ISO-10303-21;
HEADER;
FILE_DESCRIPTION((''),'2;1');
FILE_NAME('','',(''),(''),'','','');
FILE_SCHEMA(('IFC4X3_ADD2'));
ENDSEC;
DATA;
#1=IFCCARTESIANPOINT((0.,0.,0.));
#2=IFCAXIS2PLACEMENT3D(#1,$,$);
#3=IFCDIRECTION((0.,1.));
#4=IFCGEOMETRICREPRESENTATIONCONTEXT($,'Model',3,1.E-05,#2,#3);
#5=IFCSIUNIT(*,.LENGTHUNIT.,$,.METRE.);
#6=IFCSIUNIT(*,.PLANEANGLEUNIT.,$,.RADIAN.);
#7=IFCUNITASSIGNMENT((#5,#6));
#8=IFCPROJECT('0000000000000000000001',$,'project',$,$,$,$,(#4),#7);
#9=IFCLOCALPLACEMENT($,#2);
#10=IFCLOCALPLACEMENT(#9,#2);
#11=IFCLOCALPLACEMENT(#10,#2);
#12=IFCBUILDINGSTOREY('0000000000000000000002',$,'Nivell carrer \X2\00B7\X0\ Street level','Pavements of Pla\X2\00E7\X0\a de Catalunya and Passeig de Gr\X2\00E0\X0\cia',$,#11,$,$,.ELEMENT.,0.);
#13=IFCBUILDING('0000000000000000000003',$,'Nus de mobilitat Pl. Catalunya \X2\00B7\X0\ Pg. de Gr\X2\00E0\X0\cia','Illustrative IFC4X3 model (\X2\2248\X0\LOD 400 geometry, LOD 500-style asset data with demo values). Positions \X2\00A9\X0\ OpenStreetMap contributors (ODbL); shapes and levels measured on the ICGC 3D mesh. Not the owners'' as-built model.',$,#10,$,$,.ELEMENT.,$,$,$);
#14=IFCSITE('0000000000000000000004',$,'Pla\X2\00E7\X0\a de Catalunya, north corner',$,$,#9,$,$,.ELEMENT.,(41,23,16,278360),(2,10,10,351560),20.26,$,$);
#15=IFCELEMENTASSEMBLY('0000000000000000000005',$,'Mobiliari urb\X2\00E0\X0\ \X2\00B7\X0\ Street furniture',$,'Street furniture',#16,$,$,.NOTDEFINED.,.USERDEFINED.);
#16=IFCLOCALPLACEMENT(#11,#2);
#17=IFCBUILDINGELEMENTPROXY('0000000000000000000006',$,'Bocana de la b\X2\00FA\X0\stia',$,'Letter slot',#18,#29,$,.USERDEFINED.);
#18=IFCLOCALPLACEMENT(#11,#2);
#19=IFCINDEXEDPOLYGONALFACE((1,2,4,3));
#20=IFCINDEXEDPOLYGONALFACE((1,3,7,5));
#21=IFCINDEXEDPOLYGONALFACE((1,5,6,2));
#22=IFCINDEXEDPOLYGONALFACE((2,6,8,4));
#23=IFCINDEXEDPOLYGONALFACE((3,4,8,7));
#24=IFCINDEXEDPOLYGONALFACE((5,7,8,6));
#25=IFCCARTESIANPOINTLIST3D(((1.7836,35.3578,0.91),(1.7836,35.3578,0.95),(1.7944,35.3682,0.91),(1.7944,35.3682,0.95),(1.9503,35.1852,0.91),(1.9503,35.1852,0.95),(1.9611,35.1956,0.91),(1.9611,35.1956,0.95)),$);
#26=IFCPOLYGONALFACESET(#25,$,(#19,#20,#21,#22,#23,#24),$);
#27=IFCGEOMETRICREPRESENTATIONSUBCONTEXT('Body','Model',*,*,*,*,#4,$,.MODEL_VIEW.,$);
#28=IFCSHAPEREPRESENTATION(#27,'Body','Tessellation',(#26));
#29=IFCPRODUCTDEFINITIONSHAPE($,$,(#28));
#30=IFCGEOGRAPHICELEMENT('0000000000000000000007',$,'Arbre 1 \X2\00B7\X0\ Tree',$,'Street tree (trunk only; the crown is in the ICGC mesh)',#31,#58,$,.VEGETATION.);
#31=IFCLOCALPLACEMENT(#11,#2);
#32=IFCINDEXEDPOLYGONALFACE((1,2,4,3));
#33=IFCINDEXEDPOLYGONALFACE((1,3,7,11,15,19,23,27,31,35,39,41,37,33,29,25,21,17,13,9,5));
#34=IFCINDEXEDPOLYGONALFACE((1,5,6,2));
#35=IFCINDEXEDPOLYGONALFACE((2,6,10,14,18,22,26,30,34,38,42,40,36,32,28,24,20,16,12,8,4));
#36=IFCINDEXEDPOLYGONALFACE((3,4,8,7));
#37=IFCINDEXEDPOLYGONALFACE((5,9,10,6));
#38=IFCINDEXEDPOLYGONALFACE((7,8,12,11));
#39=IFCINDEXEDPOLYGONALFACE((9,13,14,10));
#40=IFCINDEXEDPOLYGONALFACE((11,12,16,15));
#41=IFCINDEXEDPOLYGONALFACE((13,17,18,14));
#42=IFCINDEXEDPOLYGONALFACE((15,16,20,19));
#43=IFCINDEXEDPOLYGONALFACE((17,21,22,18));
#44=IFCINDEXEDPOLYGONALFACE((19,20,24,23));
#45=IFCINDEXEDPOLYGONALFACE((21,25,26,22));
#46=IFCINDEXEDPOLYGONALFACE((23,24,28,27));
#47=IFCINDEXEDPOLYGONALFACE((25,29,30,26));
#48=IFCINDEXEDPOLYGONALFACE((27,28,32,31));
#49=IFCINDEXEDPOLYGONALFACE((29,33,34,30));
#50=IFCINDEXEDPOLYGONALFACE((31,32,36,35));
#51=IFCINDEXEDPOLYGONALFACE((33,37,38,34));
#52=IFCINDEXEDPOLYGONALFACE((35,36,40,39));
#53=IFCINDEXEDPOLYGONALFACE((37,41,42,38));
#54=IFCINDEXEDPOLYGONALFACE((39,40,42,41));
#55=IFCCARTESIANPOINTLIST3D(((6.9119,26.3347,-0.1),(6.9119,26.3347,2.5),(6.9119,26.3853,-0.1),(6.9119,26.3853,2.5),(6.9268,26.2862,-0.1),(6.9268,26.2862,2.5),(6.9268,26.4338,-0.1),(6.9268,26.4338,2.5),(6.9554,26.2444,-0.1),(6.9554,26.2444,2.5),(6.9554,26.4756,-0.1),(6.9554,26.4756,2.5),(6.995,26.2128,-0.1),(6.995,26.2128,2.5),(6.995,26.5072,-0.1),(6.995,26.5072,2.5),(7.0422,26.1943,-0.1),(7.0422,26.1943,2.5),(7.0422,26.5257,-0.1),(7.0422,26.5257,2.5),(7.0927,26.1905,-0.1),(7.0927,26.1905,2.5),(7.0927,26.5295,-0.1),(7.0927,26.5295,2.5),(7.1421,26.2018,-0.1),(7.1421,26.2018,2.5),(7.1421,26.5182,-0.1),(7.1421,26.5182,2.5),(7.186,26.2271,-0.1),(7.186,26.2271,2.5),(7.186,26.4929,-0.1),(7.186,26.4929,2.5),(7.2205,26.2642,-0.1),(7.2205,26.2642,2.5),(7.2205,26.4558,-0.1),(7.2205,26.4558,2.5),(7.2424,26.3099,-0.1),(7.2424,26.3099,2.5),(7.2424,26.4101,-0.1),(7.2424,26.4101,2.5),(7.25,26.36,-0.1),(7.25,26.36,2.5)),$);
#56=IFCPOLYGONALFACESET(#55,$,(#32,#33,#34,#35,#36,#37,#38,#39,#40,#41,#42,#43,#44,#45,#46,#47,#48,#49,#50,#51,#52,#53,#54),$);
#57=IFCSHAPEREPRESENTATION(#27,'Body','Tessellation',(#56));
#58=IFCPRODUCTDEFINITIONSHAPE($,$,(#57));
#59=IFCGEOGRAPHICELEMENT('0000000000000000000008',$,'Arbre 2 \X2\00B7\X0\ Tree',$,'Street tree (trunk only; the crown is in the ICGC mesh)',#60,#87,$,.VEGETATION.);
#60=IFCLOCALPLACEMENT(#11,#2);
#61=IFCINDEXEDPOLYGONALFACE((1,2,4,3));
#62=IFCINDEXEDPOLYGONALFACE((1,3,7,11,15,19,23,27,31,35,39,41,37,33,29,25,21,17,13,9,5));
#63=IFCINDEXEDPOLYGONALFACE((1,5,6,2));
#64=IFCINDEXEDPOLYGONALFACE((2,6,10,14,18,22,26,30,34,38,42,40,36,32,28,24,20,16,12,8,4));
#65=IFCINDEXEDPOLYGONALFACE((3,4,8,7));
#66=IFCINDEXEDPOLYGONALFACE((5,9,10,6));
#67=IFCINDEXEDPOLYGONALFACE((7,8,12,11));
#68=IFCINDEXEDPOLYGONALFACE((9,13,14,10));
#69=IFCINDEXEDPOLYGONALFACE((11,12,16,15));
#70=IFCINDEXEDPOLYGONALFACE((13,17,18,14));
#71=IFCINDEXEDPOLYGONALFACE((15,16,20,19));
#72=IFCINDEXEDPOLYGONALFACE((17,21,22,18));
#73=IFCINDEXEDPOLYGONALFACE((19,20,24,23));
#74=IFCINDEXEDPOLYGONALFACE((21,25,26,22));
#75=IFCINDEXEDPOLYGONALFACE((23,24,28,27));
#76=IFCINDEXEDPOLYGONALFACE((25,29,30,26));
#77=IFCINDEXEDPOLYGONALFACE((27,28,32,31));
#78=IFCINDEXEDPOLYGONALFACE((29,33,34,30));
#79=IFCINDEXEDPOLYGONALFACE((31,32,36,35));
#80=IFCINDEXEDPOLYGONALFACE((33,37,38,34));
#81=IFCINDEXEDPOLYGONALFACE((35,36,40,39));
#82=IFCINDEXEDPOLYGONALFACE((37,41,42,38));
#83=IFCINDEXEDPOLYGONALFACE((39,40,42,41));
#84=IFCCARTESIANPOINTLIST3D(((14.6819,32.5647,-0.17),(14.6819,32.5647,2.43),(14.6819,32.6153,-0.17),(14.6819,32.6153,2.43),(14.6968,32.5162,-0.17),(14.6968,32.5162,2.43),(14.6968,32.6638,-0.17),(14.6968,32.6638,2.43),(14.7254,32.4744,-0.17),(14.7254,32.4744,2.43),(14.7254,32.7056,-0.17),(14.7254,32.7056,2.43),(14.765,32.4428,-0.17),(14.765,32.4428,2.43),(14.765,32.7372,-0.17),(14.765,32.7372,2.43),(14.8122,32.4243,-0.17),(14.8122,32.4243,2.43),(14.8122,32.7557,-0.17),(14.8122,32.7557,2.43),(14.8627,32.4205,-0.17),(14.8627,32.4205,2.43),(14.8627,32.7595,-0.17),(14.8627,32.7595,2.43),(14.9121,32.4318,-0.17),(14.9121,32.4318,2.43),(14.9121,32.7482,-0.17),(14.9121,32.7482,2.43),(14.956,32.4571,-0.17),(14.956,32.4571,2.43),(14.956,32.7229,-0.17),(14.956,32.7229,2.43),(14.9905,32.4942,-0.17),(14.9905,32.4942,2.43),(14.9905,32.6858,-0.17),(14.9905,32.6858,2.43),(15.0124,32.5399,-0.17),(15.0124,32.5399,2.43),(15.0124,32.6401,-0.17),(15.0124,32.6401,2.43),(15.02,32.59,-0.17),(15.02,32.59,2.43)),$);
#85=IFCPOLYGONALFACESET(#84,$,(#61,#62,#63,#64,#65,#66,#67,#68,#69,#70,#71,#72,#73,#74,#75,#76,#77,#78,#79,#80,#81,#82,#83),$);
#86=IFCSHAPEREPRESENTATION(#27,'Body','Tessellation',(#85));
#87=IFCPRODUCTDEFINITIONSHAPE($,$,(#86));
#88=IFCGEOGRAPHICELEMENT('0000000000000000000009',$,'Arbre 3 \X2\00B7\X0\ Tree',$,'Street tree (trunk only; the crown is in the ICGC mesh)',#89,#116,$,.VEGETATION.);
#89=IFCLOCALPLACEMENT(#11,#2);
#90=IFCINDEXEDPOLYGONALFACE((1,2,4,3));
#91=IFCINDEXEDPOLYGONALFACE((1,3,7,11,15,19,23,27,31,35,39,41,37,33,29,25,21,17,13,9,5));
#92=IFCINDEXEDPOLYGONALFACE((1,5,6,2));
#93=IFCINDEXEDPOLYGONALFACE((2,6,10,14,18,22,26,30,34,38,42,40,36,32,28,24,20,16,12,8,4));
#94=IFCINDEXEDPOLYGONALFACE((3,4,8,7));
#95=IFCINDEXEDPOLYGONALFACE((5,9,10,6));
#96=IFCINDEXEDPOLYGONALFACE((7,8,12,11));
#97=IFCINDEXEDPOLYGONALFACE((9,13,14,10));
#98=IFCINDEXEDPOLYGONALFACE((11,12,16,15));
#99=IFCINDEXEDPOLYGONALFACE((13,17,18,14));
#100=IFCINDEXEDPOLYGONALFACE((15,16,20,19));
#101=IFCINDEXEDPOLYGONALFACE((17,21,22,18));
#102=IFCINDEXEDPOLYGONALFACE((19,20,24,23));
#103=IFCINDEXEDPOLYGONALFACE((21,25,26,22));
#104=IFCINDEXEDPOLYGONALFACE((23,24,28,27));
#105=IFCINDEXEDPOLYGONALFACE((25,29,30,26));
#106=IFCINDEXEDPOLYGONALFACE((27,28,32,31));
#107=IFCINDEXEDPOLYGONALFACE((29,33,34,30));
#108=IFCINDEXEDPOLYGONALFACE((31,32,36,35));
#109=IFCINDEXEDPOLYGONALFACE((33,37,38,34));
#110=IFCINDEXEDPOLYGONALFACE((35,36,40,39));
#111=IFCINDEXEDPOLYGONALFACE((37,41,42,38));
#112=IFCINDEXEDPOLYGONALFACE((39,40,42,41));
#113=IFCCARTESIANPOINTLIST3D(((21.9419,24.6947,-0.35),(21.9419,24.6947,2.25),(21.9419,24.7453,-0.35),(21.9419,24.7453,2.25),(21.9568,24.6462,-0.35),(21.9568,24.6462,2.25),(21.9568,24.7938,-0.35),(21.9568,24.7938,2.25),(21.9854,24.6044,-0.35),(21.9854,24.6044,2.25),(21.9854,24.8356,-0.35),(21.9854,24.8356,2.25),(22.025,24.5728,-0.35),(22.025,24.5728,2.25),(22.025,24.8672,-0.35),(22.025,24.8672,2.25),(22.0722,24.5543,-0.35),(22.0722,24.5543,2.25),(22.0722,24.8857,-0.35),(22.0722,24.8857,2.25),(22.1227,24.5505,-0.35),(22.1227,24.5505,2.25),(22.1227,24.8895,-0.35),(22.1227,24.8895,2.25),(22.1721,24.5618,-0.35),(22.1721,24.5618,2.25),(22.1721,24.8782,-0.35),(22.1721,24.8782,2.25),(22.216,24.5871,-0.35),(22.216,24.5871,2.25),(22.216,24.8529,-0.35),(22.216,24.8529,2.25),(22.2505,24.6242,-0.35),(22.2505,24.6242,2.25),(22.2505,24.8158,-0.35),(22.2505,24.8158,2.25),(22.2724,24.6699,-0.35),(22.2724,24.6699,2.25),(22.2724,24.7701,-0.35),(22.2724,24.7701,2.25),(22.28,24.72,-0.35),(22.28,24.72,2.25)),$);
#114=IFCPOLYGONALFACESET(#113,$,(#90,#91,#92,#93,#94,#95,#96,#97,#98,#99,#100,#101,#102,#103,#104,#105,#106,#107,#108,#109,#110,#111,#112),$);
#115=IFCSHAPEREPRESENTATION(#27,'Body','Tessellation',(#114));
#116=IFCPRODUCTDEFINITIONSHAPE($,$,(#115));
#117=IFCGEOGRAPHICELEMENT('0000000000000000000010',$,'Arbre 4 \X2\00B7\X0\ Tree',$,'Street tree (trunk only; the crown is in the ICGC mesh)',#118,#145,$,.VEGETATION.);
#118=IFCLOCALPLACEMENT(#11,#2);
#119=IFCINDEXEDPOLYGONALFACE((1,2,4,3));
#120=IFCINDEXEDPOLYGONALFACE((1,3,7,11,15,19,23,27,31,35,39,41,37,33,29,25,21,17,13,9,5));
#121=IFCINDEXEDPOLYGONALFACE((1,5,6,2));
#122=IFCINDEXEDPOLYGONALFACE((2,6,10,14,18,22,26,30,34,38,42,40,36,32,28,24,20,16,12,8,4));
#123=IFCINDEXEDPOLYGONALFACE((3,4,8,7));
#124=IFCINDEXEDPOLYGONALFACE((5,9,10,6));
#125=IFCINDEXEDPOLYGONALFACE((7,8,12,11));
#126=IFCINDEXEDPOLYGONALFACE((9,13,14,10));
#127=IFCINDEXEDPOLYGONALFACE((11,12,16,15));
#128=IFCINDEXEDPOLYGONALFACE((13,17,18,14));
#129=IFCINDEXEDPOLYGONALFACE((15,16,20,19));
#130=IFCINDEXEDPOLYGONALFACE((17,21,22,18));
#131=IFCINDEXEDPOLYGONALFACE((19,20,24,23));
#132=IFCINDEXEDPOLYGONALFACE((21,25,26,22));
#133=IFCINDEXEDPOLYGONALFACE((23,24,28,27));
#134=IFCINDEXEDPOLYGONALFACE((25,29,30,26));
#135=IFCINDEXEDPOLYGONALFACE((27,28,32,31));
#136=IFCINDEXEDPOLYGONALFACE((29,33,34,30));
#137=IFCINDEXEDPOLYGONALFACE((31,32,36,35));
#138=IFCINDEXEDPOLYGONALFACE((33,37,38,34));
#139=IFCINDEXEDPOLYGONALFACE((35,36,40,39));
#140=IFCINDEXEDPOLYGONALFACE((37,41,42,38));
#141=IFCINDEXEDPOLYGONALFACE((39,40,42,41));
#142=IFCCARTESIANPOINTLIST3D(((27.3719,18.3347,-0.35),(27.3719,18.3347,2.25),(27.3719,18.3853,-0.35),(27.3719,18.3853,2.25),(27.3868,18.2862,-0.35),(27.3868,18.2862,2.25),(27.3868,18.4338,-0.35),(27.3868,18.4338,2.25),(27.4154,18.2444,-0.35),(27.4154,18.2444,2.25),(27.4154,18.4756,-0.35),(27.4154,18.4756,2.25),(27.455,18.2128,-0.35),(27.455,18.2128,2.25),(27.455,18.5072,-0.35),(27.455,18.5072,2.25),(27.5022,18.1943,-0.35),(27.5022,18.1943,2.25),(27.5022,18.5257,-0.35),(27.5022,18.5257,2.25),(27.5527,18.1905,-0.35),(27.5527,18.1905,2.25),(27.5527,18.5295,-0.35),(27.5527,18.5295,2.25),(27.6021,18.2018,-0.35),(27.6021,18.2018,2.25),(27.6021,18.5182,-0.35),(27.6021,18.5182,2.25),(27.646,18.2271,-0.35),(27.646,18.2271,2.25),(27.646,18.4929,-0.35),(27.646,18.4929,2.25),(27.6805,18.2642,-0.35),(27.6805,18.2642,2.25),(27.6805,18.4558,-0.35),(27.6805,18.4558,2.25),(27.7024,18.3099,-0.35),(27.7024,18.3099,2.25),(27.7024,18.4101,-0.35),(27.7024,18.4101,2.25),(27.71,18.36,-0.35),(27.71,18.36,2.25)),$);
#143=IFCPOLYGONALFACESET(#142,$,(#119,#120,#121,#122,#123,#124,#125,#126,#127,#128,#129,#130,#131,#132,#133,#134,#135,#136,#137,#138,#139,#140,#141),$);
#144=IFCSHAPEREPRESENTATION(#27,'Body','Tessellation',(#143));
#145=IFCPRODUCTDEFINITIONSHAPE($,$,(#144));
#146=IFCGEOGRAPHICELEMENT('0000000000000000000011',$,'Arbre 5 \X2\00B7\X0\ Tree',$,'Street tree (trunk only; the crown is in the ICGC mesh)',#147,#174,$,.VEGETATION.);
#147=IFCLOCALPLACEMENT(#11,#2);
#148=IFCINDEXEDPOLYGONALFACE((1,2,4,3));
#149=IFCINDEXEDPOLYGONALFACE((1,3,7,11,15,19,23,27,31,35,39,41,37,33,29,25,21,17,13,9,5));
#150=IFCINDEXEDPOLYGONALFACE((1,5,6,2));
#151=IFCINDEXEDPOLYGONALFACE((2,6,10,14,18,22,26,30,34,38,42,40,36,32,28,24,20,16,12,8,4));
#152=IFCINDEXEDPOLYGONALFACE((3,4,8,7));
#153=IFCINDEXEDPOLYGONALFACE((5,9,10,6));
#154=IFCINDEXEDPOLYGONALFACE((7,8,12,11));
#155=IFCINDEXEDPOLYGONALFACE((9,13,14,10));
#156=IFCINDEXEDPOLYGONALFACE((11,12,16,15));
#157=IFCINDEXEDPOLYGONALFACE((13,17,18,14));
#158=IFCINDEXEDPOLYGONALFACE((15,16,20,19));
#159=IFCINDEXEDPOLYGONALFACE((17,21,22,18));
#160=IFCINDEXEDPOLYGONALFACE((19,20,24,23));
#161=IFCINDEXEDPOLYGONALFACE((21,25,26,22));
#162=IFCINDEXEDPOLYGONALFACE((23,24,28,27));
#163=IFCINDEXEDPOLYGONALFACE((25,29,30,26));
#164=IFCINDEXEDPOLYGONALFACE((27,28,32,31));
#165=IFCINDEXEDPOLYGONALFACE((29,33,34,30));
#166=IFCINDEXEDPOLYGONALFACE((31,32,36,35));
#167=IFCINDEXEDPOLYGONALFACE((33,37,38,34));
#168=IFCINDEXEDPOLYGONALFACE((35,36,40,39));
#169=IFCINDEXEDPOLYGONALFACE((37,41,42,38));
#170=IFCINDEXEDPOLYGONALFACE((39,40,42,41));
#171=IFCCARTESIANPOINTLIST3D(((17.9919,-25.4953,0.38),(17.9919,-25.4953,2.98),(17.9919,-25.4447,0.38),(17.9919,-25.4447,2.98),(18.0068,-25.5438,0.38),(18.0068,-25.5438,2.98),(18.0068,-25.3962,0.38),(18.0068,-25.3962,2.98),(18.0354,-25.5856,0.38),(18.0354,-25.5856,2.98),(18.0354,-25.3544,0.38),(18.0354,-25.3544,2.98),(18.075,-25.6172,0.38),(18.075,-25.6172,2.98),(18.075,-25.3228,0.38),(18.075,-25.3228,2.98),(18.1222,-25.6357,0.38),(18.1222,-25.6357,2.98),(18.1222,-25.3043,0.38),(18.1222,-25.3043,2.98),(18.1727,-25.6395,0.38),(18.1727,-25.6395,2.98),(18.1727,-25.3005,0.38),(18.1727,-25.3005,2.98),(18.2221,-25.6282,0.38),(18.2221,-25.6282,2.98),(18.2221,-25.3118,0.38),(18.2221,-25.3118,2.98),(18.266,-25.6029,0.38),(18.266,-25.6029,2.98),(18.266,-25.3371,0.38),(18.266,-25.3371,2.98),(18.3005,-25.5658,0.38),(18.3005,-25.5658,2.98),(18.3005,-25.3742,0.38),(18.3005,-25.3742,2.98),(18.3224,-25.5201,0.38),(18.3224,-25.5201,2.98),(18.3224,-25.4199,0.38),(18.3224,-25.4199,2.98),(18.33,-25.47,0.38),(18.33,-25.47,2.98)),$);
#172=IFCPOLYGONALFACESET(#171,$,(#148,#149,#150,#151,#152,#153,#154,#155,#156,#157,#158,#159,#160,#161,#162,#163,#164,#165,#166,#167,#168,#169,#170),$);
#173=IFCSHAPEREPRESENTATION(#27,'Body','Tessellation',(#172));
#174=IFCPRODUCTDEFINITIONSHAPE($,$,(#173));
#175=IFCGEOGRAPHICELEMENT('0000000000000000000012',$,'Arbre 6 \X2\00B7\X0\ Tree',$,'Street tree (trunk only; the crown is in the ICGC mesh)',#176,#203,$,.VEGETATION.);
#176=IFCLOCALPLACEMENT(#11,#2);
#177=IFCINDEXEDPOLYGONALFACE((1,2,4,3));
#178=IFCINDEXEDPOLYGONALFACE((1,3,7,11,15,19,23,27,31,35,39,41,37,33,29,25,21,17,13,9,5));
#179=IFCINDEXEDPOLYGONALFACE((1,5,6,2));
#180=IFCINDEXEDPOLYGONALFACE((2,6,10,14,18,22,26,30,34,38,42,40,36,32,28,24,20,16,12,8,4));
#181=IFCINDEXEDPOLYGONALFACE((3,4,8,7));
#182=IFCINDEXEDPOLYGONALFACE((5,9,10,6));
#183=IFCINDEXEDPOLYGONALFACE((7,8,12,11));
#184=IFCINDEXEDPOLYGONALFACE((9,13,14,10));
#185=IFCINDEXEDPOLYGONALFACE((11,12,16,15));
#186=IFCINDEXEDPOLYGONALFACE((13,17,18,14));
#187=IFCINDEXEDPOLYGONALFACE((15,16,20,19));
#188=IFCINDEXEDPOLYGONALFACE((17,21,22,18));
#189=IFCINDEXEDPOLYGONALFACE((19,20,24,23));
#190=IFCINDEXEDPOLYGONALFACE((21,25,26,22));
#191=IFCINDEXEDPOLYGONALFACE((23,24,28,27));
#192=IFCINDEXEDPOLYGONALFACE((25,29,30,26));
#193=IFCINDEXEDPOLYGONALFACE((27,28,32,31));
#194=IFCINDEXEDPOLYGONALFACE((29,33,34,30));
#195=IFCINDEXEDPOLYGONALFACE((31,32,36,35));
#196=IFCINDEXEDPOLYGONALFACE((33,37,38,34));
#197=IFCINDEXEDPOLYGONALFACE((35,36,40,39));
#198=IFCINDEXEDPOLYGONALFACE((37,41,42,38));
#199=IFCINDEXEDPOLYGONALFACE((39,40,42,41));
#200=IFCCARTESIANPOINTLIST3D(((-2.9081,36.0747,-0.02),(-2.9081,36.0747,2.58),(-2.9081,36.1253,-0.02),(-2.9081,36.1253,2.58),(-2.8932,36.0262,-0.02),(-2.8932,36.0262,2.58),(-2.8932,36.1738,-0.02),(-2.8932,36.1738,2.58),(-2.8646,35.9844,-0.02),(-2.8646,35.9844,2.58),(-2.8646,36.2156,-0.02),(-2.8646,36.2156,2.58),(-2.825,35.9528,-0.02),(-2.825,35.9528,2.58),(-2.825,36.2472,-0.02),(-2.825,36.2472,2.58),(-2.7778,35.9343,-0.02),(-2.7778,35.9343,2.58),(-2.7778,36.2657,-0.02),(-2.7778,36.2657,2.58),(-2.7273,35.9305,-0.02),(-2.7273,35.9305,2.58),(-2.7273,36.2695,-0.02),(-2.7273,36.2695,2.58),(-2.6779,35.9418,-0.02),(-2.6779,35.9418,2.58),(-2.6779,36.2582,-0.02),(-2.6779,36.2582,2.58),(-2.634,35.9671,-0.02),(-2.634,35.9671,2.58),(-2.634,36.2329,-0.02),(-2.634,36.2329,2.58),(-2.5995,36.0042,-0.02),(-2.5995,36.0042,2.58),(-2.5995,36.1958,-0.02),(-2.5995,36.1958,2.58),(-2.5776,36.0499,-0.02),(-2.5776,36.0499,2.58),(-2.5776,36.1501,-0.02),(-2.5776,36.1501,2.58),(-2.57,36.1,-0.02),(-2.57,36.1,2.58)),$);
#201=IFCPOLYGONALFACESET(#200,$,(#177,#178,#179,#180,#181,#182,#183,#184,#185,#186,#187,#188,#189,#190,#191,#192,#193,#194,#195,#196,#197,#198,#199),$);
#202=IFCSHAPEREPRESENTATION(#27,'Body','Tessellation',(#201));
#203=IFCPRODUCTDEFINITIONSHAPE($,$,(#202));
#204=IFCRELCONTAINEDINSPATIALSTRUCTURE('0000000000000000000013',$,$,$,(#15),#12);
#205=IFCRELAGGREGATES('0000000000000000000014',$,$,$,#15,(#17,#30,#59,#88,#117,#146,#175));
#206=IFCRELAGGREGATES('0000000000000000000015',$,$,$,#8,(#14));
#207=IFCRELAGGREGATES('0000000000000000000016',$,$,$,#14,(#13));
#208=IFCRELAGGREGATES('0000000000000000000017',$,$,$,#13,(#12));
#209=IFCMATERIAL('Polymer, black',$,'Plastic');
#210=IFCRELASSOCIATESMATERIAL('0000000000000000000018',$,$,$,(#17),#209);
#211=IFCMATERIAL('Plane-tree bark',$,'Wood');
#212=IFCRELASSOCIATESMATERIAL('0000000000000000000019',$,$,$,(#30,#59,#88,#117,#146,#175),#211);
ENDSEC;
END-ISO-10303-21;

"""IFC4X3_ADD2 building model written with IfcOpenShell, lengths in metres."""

from ifc_helpers import new_model, si_unit, direction, frame, frame_2d, origin, origin_2d_with_axis, place, context, subcontext, project, spatial, rectangle, circle, extrude, material, element, aggregate, save


model = new_model("IFC4X3_ADD2")

# Units and contexts
model_context = context("Model", 3, precision=1e-05, world=origin(), true_north=direction((0.0, 1.0)))
body_context = subcontext(model_context, "Body", "Model", "MODEL_VIEW")
ifc_project = project(units=[si_unit("LENGTHUNIT", "METRE"), si_unit("PLANEANGLEUNIT", "RADIAN")], contexts=[model_context])

# Site, building, storey
site_placement = place(None, origin())
site = spatial("IfcSite", under=ifc_project, at=site_placement, Name="Plaça de Catalunya, north corner", CompositionType="ELEMENT", RefLatitude=(41, 23, 16, 278360), RefLongitude=(2, 10, 10, 351560), RefElevation=20.26)
building_placement = place(site_placement, origin())
building = spatial("IfcBuilding", under=site, at=building_placement, Name="Nus de mobilitat Pl. Catalunya · Pg. de Gràcia", Description="Illustrative IFC4X3 model (≈LOD 400 geometry, LOD 500-style asset data with demo values). Positions © OpenStreetMap contributors (ODbL); shapes and levels measured on the ICGC 3D mesh. Not the owners' as-built model.", CompositionType="ELEMENT")
storey_placement = place(building_placement, origin())
storey = spatial("IfcBuildingStorey", under=building, at=storey_placement, Name="Nivell carrer · Street level", Description="Pavements of Plaça de Catalunya and Passeig de Gràcia", CompositionType="ELEMENT", Elevation=0.0)

# Element assembly
assembly_1_placement = place(building_placement, origin())
assembly_1 = element("IfcElementAssembly", 1, at=assembly_1_placement, inside=storey, Name="Mobiliari urbà · Street furniture", ObjectType="Street furniture", AssemblyPlace="NOTDEFINED", PredefinedType="USERDEFINED")

# Building element proxy
ifc_material_1 = material(Name="Polymer, black", Category="Plastic")
proxy_1_placement = place(building_placement, origin())
proxy_1 = element("IfcBuildingElementProxy", 2, at=proxy_1_placement, material=ifc_material_1, Name="Bocana de la bústia", ObjectType="Letter slot", PredefinedType="USERDEFINED", context=body_context, shape_type="SweptSolid", body=[
    extrude(rectangle(XDim=0.24, YDim=0.015, at=frame_2d((0.0, 0.0), x_axis=(0.694658, -0.71934))), frame((1.8723, 35.2767, 0.91)), (0.0, 0.0, 1.0), 0.04),
])

# Geographic elements
ifc_material_2 = material(Name="Plane-tree bark", Category="Wood")
geographic_element_1_placement = place(building_placement, origin())
geographic_element_1 = element("IfcGeographicElement", 3, at=geographic_element_1_placement, material=ifc_material_2, Name="Arbre 1 · Tree", ObjectType="Street tree (trunk only; the crown is in the ICGC mesh)", PredefinedType="VEGETATION", context=body_context, shape_type="SweptSolid", body=[
    extrude(circle(Radius=0.17, at=origin_2d_with_axis()), frame((7.08, 26.36, -0.1)), (0.0, 0.0, 1.0), 2.6),
])
geographic_element_2_placement = place(building_placement, origin())
geographic_element_2 = element("IfcGeographicElement", 4, at=geographic_element_2_placement, material=ifc_material_2, Name="Arbre 2 · Tree", ObjectType="Street tree (trunk only; the crown is in the ICGC mesh)", PredefinedType="VEGETATION", context=body_context, shape_type="SweptSolid", body=[
    extrude(circle(Radius=0.17, at=origin_2d_with_axis()), frame((14.85, 32.59, -0.17)), (0.0, 0.0, 1.0), 2.6),
])
geographic_element_3_placement = place(building_placement, origin())
geographic_element_3 = element("IfcGeographicElement", 5, at=geographic_element_3_placement, material=ifc_material_2, Name="Arbre 3 · Tree", ObjectType="Street tree (trunk only; the crown is in the ICGC mesh)", PredefinedType="VEGETATION", context=body_context, shape_type="SweptSolid", body=[
    extrude(circle(Radius=0.17, at=origin_2d_with_axis()), frame((22.11, 24.72, -0.35)), (0.0, 0.0, 1.0), 2.6),
])
geographic_element_4_placement = place(building_placement, origin())
geographic_element_4 = element("IfcGeographicElement", 6, at=geographic_element_4_placement, material=ifc_material_2, Name="Arbre 4 · Tree", ObjectType="Street tree (trunk only; the crown is in the ICGC mesh)", PredefinedType="VEGETATION", context=body_context, shape_type="SweptSolid", body=[
    extrude(circle(Radius=0.17, at=origin_2d_with_axis()), frame((27.54, 18.36, -0.35)), (0.0, 0.0, 1.0), 2.6),
])
geographic_element_5_placement = place(building_placement, origin())
geographic_element_5 = element("IfcGeographicElement", 7, at=geographic_element_5_placement, material=ifc_material_2, Name="Arbre 5 · Tree", ObjectType="Street tree (trunk only; the crown is in the ICGC mesh)", PredefinedType="VEGETATION", context=body_context, shape_type="SweptSolid", body=[
    extrude(circle(Radius=0.17, at=origin_2d_with_axis()), frame((18.16, -25.47, 0.38)), (0.0, 0.0, 1.0), 2.6),
])
geographic_element_6_placement = place(building_placement, origin())
geographic_element_6 = element("IfcGeographicElement", 8, at=geographic_element_6_placement, material=ifc_material_2, Name="Arbre 6 · Tree", ObjectType="Street tree (trunk only; the crown is in the ICGC mesh)", PredefinedType="VEGETATION", context=body_context, shape_type="SweptSolid", body=[
    extrude(circle(Radius=0.17, at=origin_2d_with_axis()), frame((-2.74, 36.1, -0.02)), (0.0, 0.0, 1.0), 2.6),
])
aggregate(assembly_1, [proxy_1, geographic_element_1, geographic_element_2, geographic_element_3, geographic_element_4, geographic_element_5, geographic_element_6])

save(model, "model.ifc")
